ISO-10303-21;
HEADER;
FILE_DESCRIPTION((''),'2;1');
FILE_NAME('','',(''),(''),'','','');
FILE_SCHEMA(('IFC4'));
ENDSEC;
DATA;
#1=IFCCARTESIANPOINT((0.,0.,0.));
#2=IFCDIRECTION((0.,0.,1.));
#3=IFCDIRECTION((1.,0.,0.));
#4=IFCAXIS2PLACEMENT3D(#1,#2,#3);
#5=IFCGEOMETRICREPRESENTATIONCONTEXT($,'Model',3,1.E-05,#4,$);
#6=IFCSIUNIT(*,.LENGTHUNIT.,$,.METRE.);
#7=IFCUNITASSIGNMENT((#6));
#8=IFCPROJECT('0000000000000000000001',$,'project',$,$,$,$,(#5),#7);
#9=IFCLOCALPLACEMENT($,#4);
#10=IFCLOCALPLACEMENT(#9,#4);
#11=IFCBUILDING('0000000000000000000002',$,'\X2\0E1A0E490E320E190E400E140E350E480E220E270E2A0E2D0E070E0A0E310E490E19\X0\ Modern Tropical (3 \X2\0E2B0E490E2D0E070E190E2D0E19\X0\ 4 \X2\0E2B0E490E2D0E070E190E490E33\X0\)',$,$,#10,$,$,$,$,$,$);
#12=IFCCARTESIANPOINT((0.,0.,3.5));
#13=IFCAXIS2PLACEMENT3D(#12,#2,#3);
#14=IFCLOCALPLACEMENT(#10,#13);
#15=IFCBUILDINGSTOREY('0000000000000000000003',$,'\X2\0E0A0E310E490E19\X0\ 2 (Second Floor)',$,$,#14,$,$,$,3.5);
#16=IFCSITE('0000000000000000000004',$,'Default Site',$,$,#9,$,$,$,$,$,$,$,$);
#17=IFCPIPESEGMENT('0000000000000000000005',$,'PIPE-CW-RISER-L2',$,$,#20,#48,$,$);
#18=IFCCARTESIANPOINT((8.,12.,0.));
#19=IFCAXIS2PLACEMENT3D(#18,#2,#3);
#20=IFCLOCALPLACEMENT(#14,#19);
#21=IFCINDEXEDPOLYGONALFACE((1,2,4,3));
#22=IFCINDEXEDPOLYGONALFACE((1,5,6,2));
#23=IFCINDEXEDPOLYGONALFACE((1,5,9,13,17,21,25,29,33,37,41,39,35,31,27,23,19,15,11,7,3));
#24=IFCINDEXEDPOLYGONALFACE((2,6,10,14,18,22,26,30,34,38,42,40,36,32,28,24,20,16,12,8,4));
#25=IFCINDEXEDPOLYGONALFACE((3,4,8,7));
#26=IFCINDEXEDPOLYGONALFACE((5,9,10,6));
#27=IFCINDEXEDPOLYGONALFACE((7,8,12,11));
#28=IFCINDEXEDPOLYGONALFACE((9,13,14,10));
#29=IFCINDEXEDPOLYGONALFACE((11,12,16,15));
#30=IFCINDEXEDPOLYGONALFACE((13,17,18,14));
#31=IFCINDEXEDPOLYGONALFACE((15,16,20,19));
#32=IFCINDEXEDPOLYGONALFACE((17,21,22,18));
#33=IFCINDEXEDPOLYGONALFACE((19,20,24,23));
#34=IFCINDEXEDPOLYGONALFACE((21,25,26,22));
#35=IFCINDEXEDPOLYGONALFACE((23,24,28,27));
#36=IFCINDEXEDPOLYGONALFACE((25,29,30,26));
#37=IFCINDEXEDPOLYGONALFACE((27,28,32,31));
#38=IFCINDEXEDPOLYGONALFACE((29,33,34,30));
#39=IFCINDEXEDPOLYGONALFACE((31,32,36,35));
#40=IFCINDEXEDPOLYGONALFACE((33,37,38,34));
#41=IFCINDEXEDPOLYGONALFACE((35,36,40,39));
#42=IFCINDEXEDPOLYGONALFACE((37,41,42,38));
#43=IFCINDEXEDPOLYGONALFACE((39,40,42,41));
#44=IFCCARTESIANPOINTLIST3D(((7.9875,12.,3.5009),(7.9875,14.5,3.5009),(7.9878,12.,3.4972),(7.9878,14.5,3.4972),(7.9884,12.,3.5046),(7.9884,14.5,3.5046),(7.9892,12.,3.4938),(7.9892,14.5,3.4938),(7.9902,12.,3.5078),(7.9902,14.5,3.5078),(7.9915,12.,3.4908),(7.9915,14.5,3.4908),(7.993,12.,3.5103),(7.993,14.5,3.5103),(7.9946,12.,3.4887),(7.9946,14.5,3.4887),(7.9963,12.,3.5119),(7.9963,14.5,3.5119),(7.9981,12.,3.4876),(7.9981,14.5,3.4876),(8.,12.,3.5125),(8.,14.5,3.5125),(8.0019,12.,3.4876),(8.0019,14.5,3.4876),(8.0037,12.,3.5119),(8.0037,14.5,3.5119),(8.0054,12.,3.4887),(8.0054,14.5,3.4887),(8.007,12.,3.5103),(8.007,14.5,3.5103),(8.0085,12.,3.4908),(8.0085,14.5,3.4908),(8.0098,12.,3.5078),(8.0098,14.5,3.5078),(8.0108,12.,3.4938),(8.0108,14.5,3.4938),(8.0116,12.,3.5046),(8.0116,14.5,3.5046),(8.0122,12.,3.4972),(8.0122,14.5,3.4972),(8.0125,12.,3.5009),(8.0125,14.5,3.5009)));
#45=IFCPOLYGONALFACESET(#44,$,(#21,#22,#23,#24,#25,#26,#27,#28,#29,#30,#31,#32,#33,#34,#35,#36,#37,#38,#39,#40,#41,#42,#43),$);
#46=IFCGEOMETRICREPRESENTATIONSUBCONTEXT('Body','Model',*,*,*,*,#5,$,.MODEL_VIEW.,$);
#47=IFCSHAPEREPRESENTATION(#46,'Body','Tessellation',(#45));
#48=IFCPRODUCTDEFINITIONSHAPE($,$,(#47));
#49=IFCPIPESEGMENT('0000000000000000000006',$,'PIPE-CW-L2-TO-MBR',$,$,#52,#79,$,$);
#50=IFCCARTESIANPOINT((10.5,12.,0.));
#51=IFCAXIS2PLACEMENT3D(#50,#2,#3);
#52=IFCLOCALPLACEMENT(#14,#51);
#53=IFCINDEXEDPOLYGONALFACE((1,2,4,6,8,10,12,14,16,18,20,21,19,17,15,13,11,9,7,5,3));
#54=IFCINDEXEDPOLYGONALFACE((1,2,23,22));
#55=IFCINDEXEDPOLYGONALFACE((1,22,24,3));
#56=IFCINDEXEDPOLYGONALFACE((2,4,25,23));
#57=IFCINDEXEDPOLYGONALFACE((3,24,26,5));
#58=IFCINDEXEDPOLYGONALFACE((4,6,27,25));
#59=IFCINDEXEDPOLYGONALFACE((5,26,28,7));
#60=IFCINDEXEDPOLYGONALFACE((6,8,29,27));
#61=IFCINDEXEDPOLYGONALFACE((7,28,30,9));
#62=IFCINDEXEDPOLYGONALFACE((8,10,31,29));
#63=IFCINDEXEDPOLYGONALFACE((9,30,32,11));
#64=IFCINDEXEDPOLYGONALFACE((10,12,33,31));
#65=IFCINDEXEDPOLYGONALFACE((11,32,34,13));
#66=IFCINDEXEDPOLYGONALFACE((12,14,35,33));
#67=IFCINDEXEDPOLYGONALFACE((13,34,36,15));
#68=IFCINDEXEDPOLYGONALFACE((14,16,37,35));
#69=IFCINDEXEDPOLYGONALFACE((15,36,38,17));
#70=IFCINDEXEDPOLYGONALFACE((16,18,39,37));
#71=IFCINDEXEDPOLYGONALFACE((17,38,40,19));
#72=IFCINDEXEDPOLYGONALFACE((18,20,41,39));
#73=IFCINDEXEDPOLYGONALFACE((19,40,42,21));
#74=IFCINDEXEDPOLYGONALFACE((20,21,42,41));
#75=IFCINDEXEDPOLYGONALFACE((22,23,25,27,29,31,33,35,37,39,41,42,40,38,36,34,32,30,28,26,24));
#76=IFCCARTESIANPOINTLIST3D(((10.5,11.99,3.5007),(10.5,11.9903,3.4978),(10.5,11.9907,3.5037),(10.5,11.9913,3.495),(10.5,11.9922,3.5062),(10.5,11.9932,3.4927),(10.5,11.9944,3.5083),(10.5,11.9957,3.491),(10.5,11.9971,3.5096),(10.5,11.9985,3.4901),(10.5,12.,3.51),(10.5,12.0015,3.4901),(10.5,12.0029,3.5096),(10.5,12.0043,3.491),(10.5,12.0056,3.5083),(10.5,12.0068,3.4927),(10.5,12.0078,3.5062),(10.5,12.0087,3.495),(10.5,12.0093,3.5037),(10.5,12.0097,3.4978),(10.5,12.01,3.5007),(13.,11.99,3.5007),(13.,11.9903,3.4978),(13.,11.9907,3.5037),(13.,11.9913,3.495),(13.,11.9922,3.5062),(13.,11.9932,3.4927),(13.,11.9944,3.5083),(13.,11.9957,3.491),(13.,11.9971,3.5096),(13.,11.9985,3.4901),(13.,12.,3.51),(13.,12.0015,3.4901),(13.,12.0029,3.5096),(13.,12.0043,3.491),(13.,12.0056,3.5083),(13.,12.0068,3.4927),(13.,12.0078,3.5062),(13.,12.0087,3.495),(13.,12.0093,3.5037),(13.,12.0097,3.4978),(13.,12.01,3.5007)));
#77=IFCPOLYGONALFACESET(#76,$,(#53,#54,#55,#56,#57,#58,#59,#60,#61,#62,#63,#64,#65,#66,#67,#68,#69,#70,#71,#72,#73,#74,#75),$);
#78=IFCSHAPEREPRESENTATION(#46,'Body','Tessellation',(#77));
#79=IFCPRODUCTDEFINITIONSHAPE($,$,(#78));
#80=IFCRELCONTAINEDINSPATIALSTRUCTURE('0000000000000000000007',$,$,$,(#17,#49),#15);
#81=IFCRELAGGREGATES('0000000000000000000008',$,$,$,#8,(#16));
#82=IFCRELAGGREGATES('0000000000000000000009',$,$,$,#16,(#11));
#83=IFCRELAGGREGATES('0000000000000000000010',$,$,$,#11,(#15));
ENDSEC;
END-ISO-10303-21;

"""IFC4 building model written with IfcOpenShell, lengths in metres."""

from ifc_helpers import new_model, entity, si_unit, frame, origin_with_axes, place, context, subcontext, project, spatial, element, save


model = new_model("IFC4")

# Units and contexts
model_context = context("Model", 3, precision=1e-05, world=origin_with_axes())
body_context = subcontext(model_context, "Body", "Model", "MODEL_VIEW")
ifc_project = project(units=[si_unit("LENGTHUNIT", "METRE")], contexts=[model_context])

# Site, building, storey
site_placement = place(None, origin_with_axes())
site = spatial("IfcSite", under=ifc_project, at=site_placement, Name="Default Site")
building_placement = place(site_placement, origin_with_axes())
building = spatial("IfcBuilding", under=site, at=building_placement, Name="บ้านเดี่ยวสองชั้น Modern Tropical (3 ห้องนอน 4 ห้องน้ำ)")
storey_placement = place(building_placement, frame((0.0, 0.0, 3.5), z_axis=(0.0, 0.0, 1.0), x_axis=(1.0, 0.0, 0.0)))
storey = spatial("IfcBuildingStorey", under=building, at=storey_placement, Name="ชั้น 2 (Second Floor)", Elevation=3.5)

# Pipe segments
pipe_segment_1_placement = place(storey_placement, frame((8.0, 12.0, 0.0), z_axis=(0.0, 0.0, 1.0), x_axis=(1.0, 0.0, 0.0)))
element("IfcPipeSegment", 1, at=pipe_segment_1_placement, inside=storey, Name="PIPE-CW-RISER-L2", context=body_context, shape_type="SweptSolid", body=[
    entity("IfcSweptDiskSolid", entity("IfcPolyline", [entity("IfcCartesianPoint", [8.0, 12.0, 3.5]), entity("IfcCartesianPoint", [8.0, 14.5, 3.5])]), 0.0125),
])
pipe_segment_2_placement = place(storey_placement, frame((10.5, 12.0, 0.0), z_axis=(0.0, 0.0, 1.0), x_axis=(1.0, 0.0, 0.0)))
element("IfcPipeSegment", 2, at=pipe_segment_2_placement, inside=storey, Name="PIPE-CW-L2-TO-MBR", context=body_context, shape_type="SweptSolid", body=[
    entity("IfcSweptDiskSolid", entity("IfcPolyline", [entity("IfcCartesianPoint", [10.5, 12.0, 3.5]), entity("IfcCartesianPoint", [13.0, 12.0, 3.5])]), 0.01),
])

save(model, "model.ifc")
